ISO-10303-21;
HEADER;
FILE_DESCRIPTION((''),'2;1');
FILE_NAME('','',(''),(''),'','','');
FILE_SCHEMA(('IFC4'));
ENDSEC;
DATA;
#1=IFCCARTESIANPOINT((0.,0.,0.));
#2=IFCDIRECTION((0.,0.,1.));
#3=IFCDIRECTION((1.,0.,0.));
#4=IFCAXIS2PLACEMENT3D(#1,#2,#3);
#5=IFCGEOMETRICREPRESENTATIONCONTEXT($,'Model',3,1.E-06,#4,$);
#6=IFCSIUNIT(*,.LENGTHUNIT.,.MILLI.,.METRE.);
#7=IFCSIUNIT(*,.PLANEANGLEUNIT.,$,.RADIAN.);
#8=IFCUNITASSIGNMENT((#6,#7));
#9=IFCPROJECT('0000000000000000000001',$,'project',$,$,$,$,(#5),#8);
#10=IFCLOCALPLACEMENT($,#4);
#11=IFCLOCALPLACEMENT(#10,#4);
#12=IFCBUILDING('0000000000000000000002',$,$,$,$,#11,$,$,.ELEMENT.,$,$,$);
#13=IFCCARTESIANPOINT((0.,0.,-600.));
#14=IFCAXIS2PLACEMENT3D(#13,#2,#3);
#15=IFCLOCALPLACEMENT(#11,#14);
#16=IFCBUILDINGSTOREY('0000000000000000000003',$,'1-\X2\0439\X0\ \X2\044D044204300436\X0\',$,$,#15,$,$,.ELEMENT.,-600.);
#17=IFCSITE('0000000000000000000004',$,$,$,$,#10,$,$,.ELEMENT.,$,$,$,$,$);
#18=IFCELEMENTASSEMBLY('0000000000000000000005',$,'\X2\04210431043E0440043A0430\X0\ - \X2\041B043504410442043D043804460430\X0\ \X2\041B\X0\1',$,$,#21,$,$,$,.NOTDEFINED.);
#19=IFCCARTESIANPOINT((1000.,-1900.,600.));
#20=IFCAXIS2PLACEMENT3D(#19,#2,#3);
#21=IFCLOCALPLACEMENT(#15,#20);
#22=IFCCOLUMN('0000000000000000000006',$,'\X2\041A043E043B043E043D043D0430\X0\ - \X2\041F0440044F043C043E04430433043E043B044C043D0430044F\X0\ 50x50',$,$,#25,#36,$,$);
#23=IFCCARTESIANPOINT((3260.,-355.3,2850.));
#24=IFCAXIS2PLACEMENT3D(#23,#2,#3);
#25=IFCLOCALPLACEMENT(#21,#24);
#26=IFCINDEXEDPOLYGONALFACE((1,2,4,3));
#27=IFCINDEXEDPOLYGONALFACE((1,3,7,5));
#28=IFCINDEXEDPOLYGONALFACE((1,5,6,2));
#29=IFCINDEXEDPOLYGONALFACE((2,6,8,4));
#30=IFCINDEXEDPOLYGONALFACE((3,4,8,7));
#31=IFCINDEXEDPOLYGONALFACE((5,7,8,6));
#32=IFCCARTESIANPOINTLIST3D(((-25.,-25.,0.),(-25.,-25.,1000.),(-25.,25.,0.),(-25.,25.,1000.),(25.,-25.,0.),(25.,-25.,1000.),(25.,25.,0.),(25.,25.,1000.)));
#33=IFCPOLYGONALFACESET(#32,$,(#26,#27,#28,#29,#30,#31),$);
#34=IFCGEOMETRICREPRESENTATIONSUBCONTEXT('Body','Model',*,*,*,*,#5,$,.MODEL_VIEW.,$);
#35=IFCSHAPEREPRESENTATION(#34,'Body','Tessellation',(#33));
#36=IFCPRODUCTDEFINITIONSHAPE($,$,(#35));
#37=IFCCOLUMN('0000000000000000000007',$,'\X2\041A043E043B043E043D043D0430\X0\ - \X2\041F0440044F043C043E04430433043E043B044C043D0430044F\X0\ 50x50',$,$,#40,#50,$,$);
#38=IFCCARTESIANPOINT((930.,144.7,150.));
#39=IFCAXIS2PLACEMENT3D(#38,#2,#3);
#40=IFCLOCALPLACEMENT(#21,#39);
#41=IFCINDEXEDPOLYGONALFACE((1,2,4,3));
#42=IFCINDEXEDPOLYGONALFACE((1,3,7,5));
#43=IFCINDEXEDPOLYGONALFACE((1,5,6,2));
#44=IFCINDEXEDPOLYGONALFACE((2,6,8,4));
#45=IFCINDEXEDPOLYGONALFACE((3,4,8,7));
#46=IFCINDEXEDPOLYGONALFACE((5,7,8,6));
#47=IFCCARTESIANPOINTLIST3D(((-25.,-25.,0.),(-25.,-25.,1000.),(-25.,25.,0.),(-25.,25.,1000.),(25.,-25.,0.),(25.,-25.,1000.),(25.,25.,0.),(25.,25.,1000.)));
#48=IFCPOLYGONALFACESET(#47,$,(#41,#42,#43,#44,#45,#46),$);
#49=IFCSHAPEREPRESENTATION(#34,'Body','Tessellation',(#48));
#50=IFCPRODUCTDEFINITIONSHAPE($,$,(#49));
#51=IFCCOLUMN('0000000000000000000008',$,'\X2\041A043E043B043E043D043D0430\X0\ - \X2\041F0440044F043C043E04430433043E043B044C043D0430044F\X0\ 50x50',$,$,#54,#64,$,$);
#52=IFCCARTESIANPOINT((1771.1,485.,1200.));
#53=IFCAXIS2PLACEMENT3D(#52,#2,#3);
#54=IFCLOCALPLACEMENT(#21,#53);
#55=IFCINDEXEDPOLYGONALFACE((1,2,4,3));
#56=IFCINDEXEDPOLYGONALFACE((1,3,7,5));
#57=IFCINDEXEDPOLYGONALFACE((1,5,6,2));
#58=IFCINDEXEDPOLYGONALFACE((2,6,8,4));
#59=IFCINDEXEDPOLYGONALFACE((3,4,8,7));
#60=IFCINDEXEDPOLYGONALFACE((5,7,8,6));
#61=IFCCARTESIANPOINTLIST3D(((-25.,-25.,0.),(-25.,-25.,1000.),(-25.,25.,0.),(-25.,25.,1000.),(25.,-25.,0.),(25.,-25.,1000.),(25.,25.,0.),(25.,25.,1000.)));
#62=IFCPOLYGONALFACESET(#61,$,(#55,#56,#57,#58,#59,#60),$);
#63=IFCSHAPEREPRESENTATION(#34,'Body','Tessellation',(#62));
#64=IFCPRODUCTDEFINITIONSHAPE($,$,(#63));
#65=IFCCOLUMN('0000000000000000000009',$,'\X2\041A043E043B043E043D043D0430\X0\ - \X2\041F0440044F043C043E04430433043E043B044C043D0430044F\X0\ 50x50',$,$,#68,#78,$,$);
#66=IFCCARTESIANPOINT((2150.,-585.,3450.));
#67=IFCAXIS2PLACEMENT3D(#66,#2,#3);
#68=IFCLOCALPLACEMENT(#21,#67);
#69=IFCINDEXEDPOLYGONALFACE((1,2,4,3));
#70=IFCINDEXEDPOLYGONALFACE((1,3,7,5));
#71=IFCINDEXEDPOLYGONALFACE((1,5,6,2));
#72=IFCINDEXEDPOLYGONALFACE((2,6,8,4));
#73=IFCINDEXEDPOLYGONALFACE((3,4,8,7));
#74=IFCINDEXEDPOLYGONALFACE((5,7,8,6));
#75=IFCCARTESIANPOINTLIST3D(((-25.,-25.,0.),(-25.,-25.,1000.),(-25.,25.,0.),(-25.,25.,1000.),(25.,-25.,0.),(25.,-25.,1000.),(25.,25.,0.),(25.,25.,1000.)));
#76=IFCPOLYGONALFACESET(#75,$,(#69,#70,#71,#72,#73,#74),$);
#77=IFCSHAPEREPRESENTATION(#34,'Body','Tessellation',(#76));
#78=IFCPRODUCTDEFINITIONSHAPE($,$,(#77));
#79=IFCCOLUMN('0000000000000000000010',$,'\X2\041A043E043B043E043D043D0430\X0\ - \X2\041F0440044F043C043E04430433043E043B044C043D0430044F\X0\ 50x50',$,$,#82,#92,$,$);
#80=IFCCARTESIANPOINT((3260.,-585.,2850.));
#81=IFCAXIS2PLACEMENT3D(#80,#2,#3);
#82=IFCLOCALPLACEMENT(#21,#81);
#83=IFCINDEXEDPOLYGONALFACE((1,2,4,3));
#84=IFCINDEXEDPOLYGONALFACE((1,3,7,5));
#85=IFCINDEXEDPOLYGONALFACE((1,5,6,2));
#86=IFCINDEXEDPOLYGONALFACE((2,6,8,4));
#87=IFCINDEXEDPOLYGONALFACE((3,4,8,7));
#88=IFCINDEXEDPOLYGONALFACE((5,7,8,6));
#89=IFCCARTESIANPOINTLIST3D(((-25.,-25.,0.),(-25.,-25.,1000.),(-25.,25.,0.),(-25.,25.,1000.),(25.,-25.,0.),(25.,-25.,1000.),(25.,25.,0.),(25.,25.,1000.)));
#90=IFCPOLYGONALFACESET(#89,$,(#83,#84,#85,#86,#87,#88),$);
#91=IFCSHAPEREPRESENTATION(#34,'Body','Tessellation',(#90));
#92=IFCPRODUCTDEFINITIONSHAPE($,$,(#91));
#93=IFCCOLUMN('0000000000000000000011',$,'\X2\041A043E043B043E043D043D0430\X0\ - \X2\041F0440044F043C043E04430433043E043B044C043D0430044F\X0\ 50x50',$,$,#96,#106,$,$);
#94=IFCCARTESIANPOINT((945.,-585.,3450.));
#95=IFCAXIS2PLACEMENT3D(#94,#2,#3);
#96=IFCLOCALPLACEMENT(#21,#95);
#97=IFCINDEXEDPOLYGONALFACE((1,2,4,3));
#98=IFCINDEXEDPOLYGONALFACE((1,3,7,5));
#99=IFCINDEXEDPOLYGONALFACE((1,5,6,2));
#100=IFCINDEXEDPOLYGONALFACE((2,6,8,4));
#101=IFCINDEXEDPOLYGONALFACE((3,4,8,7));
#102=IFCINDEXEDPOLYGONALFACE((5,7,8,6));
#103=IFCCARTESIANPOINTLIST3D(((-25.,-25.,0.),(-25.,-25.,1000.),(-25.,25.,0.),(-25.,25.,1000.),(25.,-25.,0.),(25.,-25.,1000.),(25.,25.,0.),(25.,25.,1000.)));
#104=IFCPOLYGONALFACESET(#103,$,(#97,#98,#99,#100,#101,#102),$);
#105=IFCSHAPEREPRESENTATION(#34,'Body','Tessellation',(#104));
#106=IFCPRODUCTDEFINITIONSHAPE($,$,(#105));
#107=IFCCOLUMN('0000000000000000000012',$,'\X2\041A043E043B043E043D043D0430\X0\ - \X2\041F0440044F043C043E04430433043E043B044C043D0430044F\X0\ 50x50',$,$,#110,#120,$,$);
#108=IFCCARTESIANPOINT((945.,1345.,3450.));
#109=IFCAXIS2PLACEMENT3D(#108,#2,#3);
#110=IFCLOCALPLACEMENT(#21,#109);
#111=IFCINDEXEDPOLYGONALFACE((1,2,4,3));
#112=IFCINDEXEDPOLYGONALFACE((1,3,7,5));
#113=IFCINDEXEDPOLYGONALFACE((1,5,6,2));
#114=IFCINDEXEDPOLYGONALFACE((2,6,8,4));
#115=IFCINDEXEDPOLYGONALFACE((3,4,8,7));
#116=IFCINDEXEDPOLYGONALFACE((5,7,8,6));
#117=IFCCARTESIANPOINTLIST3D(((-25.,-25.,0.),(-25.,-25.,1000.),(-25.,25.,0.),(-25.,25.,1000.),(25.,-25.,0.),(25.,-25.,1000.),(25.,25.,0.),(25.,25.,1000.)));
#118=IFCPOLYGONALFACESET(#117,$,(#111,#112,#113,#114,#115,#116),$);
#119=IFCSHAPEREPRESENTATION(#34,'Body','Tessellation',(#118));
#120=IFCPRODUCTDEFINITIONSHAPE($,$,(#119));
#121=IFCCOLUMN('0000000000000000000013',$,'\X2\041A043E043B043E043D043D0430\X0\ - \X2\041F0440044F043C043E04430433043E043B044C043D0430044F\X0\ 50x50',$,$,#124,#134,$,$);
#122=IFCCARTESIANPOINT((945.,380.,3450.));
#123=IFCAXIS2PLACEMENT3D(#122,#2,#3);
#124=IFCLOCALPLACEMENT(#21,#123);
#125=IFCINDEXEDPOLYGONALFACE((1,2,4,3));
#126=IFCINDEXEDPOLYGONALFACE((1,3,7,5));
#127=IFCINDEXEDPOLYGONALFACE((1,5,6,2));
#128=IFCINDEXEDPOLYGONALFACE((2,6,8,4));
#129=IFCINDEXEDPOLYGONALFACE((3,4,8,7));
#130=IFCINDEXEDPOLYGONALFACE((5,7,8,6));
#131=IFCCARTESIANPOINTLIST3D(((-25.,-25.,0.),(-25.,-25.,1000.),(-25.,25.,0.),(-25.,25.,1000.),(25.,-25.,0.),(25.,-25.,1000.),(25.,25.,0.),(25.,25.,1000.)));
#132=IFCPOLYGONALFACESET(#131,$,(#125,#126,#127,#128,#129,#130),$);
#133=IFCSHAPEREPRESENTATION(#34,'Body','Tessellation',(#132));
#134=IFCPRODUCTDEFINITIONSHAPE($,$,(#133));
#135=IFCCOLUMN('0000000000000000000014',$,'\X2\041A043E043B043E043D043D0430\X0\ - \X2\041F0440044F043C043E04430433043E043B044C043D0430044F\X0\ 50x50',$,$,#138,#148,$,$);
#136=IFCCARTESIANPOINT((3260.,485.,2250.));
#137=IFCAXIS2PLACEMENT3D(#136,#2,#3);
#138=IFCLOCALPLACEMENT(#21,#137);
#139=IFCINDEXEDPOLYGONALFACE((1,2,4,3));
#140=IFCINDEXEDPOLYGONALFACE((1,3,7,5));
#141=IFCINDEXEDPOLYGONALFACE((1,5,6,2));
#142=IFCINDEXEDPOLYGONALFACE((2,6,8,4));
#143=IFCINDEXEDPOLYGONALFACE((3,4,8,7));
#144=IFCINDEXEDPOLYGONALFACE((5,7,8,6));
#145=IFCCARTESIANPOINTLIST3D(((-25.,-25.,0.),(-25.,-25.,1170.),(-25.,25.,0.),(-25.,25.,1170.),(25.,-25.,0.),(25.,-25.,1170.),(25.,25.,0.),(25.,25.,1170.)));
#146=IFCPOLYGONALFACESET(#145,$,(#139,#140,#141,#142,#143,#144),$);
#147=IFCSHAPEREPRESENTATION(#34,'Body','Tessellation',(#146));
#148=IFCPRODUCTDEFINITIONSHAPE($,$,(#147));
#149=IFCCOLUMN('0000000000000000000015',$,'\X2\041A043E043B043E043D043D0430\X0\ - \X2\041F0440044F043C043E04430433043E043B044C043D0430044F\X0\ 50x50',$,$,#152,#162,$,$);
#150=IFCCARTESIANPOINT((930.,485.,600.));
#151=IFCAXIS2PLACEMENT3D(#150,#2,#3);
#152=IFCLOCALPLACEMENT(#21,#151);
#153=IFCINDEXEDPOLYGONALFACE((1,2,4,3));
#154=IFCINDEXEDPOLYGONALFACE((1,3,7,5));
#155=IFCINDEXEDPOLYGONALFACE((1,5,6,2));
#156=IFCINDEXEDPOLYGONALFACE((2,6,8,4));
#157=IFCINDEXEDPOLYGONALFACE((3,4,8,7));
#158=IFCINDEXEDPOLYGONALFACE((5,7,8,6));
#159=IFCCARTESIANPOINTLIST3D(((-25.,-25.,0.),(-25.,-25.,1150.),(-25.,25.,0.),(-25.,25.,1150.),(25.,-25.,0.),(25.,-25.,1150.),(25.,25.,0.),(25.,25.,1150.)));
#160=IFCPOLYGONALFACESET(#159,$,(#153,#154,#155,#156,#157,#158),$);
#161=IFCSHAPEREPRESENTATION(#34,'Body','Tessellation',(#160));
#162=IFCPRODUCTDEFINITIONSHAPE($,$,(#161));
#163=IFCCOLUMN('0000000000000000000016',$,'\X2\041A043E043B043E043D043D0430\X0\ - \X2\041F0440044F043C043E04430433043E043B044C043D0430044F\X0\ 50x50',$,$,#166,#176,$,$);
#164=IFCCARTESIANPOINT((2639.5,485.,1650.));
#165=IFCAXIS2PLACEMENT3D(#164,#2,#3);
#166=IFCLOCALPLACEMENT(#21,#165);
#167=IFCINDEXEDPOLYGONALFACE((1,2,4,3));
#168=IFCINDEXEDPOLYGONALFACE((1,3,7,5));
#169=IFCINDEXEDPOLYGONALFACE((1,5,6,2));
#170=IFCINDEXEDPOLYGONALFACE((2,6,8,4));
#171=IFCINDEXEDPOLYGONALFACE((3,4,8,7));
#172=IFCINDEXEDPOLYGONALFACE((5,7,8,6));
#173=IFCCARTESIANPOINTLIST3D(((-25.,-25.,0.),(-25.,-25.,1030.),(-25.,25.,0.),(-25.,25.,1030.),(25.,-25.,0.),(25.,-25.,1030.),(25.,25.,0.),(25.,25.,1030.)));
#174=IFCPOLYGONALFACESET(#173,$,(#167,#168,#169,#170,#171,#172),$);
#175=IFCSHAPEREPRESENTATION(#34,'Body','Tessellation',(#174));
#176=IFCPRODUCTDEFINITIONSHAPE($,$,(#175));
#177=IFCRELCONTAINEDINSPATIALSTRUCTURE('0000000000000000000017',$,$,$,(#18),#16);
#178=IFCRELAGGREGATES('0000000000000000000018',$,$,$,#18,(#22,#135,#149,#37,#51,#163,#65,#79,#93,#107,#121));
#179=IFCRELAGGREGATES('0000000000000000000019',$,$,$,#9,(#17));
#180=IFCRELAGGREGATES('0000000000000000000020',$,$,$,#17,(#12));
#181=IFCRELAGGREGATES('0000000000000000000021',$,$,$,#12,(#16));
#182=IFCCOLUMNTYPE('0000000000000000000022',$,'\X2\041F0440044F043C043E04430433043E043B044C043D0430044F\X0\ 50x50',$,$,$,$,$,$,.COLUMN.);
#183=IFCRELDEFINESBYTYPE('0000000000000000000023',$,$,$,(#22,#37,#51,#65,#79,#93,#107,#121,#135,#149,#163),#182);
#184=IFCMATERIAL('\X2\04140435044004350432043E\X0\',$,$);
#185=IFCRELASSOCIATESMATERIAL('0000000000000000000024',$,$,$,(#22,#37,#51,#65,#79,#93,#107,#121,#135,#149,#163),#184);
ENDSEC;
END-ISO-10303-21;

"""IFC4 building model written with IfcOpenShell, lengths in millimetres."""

from ifc_helpers import new_model, si_unit, frame, origin_with_axes, place, context, subcontext, project, spatial, line, indexed_curve, outline, extrude, source, transform, mapped, material, type_object, element, aggregate, save


model = new_model("IFC4")

# Units and contexts
model_context = context("Model", 3, precision=1e-06, world=origin_with_axes())
body_context = subcontext(model_context, "Body", "Model", "MODEL_VIEW")
ifc_project = project(units=[si_unit("LENGTHUNIT", "METRE", prefix="MILLI"), si_unit("PLANEANGLEUNIT", "RADIAN")], contexts=[model_context])

# Site, building, storey
site_placement = place(None, origin_with_axes())
site = spatial("IfcSite", under=ifc_project, at=site_placement, CompositionType="ELEMENT")
building_placement = place(site_placement, origin_with_axes())
building = spatial("IfcBuilding", under=site, at=building_placement, CompositionType="ELEMENT")
storey_placement = place(building_placement, frame((0.0, 0.0, -600.0), z_axis=(0.0, 0.0, 1.0), x_axis=(1.0, 0.0, 0.0)))
storey = spatial("IfcBuildingStorey", under=building, at=storey_placement, Name="1-й этаж", CompositionType="ELEMENT", Elevation=-600.0)

# Element assembly, columns
assembly_placement = place(storey_placement, frame((1000.0, -1900.0, 600.0), z_axis=(0.0, 0.0, 1.0), x_axis=(1.0, 0.0, 0.0)))
assembly = element("IfcElementAssembly", 1, at=assembly_placement, inside=storey, Name="Сборка - Лестница Л1", PredefinedType="NOTDEFINED")
ifc_material = material(Name="Дерево")
column_type = type_object("IfcColumnType", Name="Прямоугольная 50x50", PredefinedType="COLUMN")
shared_shape_1 = source(origin_with_axes(), body_context, "Body", "SweptSolid", [
    extrude(outline(indexed_curve([(-25.0, -25.0), (25.0, -25.0), (25.0, 25.0), (-25.0, 25.0)], segments=[line(1, 2), line(2, 3), line(3, 4), line(4, 1)])), origin_with_axes(), (0.0, 0.0, 1.0), 1000.0),
])
column_1_placement = place(assembly_placement, frame((3260.0, -355.3, 2850.0), z_axis=(0.0, 0.0, 1.0), x_axis=(1.0, 0.0, 0.0)))
column_1 = element("IfcColumn", 2, at=column_1_placement, type_object=column_type, material=ifc_material, Name="Колонна - Прямоугольная 50x50", context=body_context, shape_type="MappedRepresentation", body=[
    mapped(shared_shape_1, transform((0.0, 0.0, 0.0), x_axis=(1.0, 0.0, 0.0), y_axis=(0.0, 1.0, 0.0), z_axis=(0.0, 0.0, 1.0), scale=1.0)),
])
column_2_placement = place(assembly_placement, frame((930.0, 144.7, 150.0), z_axis=(0.0, 0.0, 1.0), x_axis=(1.0, 0.0, 0.0)))
column_2 = element("IfcColumn", 3, at=column_2_placement, type_object=column_type, material=ifc_material, Name="Колонна - Прямоугольная 50x50", context=body_context, shape_type="MappedRepresentation", body=[
    mapped(shared_shape_1, transform((0.0, 0.0, 0.0), x_axis=(1.0, 0.0, 0.0), y_axis=(0.0, 1.0, 0.0), z_axis=(0.0, 0.0, 1.0), scale=1.0)),
])
column_3_placement = place(assembly_placement, frame((1771.1, 485.0, 1200.0), z_axis=(0.0, 0.0, 1.0), x_axis=(1.0, 0.0, 0.0)))
column_3 = element("IfcColumn", 4, at=column_3_placement, type_object=column_type, material=ifc_material, Name="Колонна - Прямоугольная 50x50", context=body_context, shape_type="MappedRepresentation", body=[
    mapped(shared_shape_1, transform((0.0, 0.0, 0.0), x_axis=(1.0, 0.0, 0.0), y_axis=(0.0, 1.0, 0.0), z_axis=(0.0, 0.0, 1.0), scale=1.0)),
])
column_4_placement = place(assembly_placement, frame((2150.0, -585.0, 3450.0), z_axis=(0.0, 0.0, 1.0), x_axis=(1.0, 0.0, 0.0)))
column_4 = element("IfcColumn", 5, at=column_4_placement, type_object=column_type, material=ifc_material, Name="Колонна - Прямоугольная 50x50", context=body_context, shape_type="MappedRepresentation", body=[
    mapped(shared_shape_1, transform((0.0, 0.0, 0.0), x_axis=(1.0, 0.0, 0.0), y_axis=(0.0, 1.0, 0.0), z_axis=(0.0, 0.0, 1.0), scale=1.0)),
])
column_5_placement = place(assembly_placement, frame((3260.0, -585.0, 2850.0), z_axis=(0.0, 0.0, 1.0), x_axis=(1.0, 0.0, 0.0)))
column_5 = element("IfcColumn", 6, at=column_5_placement, type_object=column_type, material=ifc_material, Name="Колонна - Прямоугольная 50x50", context=body_context, shape_type="MappedRepresentation", body=[
    mapped(shared_shape_1, transform((0.0, 0.0, 0.0), x_axis=(1.0, 0.0, 0.0), y_axis=(0.0, 1.0, 0.0), z_axis=(0.0, 0.0, 1.0), scale=1.0)),
])
column_6_placement = place(assembly_placement, frame((945.0, -585.0, 3450.0), z_axis=(0.0, 0.0, 1.0), x_axis=(1.0, 0.0, 0.0)))
column_6 = element("IfcColumn", 7, at=column_6_placement, type_object=column_type, material=ifc_material, Name="Колонна - Прямоугольная 50x50", context=body_context, shape_type="MappedRepresentation", body=[
    mapped(shared_shape_1, transform((0.0, 0.0, 0.0), x_axis=(1.0, 0.0, 0.0), y_axis=(0.0, 1.0, 0.0), z_axis=(0.0, 0.0, 1.0), scale=1.0)),
])
column_7_placement = place(assembly_placement, frame((945.0, 1345.0, 3450.0), z_axis=(0.0, 0.0, 1.0), x_axis=(1.0, 0.0, 0.0)))
column_7 = element("IfcColumn", 8, at=column_7_placement, type_object=column_type, material=ifc_material, Name="Колонна - Прямоугольная 50x50", context=body_context, shape_type="MappedRepresentation", body=[
    mapped(shared_shape_1, transform((0.0, 0.0, 0.0), x_axis=(1.0, 0.0, 0.0), y_axis=(0.0, 1.0, 0.0), z_axis=(0.0, 0.0, 1.0), scale=1.0)),
])
column_8_placement = place(assembly_placement, frame((945.0, 380.0, 3450.0), z_axis=(0.0, 0.0, 1.0), x_axis=(1.0, 0.0, 0.0)))
column_8 = element("IfcColumn", 9, at=column_8_placement, type_object=column_type, material=ifc_material, Name="Колонна - Прямоугольная 50x50", context=body_context, shape_type="MappedRepresentation", body=[
    mapped(shared_shape_1, transform((0.0, 0.0, 0.0), x_axis=(1.0, 0.0, 0.0), y_axis=(0.0, 1.0, 0.0), z_axis=(0.0, 0.0, 1.0), scale=1.0)),
])
shared_shape_2 = source(origin_with_axes(), body_context, "Body", "SweptSolid", [
    extrude(outline(indexed_curve([(-25.0, -25.0), (25.0, -25.0), (25.0, 25.0), (-25.0, 25.0)], segments=[line(1, 2), line(2, 3), line(3, 4), line(4, 1)])), origin_with_axes(), (0.0, 0.0, 1.0), 1170.0),
])
column_9_placement = place(assembly_placement, frame((3260.0, 485.0, 2250.0), z_axis=(0.0, 0.0, 1.0), x_axis=(1.0, 0.0, 0.0)))
column_9 = element("IfcColumn", 10, at=column_9_placement, type_object=column_type, material=ifc_material, Name="Колонна - Прямоугольная 50x50", context=body_context, shape_type="MappedRepresentation", body=[
    mapped(shared_shape_2, transform((0.0, 0.0, 0.0), x_axis=(1.0, 0.0, 0.0), y_axis=(0.0, 1.0, 0.0), z_axis=(0.0, 0.0, 1.0), scale=1.0)),
])
shared_shape_3 = source(origin_with_axes(), body_context, "Body", "SweptSolid", [
    extrude(outline(indexed_curve([(-25.0, -25.0), (25.0, -25.0), (25.0, 25.0), (-25.0, 25.0)], segments=[line(1, 2), line(2, 3), line(3, 4), line(4, 1)])), origin_with_axes(), (0.0, 0.0, 1.0), 1150.0),
])
column_10_placement = place(assembly_placement, frame((930.0, 485.0, 600.0), z_axis=(0.0, 0.0, 1.0), x_axis=(1.0, 0.0, 0.0)))
column_10 = element("IfcColumn", 11, at=column_10_placement, type_object=column_type, material=ifc_material, Name="Колонна - Прямоугольная 50x50", context=body_context, shape_type="MappedRepresentation", body=[
    mapped(shared_shape_3, transform((0.0, 0.0, 0.0), x_axis=(1.0, 0.0, 0.0), y_axis=(0.0, 1.0, 0.0), z_axis=(0.0, 0.0, 1.0), scale=1.0)),
])
shared_shape_4 = source(origin_with_axes(), body_context, "Body", "SweptSolid", [
    extrude(outline(indexed_curve([(-25.0, -25.0), (25.0, -25.0), (25.0, 25.0), (-25.0, 25.0)], segments=[line(1, 2), line(2, 3), line(3, 4), line(4, 1)])), origin_with_axes(), (0.0, 0.0, 1.0), 1030.0),
])
column_11_placement = place(assembly_placement, frame((2639.5, 485.0, 1650.0), z_axis=(0.0, 0.0, 1.0), x_axis=(1.0, 0.0, 0.0)))
column_11 = element("IfcColumn", 12, at=column_11_placement, type_object=column_type, material=ifc_material, Name="Колонна - Прямоугольная 50x50", context=body_context, shape_type="MappedRepresentation", body=[
    mapped(shared_shape_4, transform((0.0, 0.0, 0.0), x_axis=(1.0, 0.0, 0.0), y_axis=(0.0, 1.0, 0.0), z_axis=(0.0, 0.0, 1.0), scale=1.0)),
])
aggregate(assembly, [column_1, column_9, column_10, column_2, column_3, column_11, column_4, column_5, column_6, column_7, column_8])

save(model, "model.ifc")
